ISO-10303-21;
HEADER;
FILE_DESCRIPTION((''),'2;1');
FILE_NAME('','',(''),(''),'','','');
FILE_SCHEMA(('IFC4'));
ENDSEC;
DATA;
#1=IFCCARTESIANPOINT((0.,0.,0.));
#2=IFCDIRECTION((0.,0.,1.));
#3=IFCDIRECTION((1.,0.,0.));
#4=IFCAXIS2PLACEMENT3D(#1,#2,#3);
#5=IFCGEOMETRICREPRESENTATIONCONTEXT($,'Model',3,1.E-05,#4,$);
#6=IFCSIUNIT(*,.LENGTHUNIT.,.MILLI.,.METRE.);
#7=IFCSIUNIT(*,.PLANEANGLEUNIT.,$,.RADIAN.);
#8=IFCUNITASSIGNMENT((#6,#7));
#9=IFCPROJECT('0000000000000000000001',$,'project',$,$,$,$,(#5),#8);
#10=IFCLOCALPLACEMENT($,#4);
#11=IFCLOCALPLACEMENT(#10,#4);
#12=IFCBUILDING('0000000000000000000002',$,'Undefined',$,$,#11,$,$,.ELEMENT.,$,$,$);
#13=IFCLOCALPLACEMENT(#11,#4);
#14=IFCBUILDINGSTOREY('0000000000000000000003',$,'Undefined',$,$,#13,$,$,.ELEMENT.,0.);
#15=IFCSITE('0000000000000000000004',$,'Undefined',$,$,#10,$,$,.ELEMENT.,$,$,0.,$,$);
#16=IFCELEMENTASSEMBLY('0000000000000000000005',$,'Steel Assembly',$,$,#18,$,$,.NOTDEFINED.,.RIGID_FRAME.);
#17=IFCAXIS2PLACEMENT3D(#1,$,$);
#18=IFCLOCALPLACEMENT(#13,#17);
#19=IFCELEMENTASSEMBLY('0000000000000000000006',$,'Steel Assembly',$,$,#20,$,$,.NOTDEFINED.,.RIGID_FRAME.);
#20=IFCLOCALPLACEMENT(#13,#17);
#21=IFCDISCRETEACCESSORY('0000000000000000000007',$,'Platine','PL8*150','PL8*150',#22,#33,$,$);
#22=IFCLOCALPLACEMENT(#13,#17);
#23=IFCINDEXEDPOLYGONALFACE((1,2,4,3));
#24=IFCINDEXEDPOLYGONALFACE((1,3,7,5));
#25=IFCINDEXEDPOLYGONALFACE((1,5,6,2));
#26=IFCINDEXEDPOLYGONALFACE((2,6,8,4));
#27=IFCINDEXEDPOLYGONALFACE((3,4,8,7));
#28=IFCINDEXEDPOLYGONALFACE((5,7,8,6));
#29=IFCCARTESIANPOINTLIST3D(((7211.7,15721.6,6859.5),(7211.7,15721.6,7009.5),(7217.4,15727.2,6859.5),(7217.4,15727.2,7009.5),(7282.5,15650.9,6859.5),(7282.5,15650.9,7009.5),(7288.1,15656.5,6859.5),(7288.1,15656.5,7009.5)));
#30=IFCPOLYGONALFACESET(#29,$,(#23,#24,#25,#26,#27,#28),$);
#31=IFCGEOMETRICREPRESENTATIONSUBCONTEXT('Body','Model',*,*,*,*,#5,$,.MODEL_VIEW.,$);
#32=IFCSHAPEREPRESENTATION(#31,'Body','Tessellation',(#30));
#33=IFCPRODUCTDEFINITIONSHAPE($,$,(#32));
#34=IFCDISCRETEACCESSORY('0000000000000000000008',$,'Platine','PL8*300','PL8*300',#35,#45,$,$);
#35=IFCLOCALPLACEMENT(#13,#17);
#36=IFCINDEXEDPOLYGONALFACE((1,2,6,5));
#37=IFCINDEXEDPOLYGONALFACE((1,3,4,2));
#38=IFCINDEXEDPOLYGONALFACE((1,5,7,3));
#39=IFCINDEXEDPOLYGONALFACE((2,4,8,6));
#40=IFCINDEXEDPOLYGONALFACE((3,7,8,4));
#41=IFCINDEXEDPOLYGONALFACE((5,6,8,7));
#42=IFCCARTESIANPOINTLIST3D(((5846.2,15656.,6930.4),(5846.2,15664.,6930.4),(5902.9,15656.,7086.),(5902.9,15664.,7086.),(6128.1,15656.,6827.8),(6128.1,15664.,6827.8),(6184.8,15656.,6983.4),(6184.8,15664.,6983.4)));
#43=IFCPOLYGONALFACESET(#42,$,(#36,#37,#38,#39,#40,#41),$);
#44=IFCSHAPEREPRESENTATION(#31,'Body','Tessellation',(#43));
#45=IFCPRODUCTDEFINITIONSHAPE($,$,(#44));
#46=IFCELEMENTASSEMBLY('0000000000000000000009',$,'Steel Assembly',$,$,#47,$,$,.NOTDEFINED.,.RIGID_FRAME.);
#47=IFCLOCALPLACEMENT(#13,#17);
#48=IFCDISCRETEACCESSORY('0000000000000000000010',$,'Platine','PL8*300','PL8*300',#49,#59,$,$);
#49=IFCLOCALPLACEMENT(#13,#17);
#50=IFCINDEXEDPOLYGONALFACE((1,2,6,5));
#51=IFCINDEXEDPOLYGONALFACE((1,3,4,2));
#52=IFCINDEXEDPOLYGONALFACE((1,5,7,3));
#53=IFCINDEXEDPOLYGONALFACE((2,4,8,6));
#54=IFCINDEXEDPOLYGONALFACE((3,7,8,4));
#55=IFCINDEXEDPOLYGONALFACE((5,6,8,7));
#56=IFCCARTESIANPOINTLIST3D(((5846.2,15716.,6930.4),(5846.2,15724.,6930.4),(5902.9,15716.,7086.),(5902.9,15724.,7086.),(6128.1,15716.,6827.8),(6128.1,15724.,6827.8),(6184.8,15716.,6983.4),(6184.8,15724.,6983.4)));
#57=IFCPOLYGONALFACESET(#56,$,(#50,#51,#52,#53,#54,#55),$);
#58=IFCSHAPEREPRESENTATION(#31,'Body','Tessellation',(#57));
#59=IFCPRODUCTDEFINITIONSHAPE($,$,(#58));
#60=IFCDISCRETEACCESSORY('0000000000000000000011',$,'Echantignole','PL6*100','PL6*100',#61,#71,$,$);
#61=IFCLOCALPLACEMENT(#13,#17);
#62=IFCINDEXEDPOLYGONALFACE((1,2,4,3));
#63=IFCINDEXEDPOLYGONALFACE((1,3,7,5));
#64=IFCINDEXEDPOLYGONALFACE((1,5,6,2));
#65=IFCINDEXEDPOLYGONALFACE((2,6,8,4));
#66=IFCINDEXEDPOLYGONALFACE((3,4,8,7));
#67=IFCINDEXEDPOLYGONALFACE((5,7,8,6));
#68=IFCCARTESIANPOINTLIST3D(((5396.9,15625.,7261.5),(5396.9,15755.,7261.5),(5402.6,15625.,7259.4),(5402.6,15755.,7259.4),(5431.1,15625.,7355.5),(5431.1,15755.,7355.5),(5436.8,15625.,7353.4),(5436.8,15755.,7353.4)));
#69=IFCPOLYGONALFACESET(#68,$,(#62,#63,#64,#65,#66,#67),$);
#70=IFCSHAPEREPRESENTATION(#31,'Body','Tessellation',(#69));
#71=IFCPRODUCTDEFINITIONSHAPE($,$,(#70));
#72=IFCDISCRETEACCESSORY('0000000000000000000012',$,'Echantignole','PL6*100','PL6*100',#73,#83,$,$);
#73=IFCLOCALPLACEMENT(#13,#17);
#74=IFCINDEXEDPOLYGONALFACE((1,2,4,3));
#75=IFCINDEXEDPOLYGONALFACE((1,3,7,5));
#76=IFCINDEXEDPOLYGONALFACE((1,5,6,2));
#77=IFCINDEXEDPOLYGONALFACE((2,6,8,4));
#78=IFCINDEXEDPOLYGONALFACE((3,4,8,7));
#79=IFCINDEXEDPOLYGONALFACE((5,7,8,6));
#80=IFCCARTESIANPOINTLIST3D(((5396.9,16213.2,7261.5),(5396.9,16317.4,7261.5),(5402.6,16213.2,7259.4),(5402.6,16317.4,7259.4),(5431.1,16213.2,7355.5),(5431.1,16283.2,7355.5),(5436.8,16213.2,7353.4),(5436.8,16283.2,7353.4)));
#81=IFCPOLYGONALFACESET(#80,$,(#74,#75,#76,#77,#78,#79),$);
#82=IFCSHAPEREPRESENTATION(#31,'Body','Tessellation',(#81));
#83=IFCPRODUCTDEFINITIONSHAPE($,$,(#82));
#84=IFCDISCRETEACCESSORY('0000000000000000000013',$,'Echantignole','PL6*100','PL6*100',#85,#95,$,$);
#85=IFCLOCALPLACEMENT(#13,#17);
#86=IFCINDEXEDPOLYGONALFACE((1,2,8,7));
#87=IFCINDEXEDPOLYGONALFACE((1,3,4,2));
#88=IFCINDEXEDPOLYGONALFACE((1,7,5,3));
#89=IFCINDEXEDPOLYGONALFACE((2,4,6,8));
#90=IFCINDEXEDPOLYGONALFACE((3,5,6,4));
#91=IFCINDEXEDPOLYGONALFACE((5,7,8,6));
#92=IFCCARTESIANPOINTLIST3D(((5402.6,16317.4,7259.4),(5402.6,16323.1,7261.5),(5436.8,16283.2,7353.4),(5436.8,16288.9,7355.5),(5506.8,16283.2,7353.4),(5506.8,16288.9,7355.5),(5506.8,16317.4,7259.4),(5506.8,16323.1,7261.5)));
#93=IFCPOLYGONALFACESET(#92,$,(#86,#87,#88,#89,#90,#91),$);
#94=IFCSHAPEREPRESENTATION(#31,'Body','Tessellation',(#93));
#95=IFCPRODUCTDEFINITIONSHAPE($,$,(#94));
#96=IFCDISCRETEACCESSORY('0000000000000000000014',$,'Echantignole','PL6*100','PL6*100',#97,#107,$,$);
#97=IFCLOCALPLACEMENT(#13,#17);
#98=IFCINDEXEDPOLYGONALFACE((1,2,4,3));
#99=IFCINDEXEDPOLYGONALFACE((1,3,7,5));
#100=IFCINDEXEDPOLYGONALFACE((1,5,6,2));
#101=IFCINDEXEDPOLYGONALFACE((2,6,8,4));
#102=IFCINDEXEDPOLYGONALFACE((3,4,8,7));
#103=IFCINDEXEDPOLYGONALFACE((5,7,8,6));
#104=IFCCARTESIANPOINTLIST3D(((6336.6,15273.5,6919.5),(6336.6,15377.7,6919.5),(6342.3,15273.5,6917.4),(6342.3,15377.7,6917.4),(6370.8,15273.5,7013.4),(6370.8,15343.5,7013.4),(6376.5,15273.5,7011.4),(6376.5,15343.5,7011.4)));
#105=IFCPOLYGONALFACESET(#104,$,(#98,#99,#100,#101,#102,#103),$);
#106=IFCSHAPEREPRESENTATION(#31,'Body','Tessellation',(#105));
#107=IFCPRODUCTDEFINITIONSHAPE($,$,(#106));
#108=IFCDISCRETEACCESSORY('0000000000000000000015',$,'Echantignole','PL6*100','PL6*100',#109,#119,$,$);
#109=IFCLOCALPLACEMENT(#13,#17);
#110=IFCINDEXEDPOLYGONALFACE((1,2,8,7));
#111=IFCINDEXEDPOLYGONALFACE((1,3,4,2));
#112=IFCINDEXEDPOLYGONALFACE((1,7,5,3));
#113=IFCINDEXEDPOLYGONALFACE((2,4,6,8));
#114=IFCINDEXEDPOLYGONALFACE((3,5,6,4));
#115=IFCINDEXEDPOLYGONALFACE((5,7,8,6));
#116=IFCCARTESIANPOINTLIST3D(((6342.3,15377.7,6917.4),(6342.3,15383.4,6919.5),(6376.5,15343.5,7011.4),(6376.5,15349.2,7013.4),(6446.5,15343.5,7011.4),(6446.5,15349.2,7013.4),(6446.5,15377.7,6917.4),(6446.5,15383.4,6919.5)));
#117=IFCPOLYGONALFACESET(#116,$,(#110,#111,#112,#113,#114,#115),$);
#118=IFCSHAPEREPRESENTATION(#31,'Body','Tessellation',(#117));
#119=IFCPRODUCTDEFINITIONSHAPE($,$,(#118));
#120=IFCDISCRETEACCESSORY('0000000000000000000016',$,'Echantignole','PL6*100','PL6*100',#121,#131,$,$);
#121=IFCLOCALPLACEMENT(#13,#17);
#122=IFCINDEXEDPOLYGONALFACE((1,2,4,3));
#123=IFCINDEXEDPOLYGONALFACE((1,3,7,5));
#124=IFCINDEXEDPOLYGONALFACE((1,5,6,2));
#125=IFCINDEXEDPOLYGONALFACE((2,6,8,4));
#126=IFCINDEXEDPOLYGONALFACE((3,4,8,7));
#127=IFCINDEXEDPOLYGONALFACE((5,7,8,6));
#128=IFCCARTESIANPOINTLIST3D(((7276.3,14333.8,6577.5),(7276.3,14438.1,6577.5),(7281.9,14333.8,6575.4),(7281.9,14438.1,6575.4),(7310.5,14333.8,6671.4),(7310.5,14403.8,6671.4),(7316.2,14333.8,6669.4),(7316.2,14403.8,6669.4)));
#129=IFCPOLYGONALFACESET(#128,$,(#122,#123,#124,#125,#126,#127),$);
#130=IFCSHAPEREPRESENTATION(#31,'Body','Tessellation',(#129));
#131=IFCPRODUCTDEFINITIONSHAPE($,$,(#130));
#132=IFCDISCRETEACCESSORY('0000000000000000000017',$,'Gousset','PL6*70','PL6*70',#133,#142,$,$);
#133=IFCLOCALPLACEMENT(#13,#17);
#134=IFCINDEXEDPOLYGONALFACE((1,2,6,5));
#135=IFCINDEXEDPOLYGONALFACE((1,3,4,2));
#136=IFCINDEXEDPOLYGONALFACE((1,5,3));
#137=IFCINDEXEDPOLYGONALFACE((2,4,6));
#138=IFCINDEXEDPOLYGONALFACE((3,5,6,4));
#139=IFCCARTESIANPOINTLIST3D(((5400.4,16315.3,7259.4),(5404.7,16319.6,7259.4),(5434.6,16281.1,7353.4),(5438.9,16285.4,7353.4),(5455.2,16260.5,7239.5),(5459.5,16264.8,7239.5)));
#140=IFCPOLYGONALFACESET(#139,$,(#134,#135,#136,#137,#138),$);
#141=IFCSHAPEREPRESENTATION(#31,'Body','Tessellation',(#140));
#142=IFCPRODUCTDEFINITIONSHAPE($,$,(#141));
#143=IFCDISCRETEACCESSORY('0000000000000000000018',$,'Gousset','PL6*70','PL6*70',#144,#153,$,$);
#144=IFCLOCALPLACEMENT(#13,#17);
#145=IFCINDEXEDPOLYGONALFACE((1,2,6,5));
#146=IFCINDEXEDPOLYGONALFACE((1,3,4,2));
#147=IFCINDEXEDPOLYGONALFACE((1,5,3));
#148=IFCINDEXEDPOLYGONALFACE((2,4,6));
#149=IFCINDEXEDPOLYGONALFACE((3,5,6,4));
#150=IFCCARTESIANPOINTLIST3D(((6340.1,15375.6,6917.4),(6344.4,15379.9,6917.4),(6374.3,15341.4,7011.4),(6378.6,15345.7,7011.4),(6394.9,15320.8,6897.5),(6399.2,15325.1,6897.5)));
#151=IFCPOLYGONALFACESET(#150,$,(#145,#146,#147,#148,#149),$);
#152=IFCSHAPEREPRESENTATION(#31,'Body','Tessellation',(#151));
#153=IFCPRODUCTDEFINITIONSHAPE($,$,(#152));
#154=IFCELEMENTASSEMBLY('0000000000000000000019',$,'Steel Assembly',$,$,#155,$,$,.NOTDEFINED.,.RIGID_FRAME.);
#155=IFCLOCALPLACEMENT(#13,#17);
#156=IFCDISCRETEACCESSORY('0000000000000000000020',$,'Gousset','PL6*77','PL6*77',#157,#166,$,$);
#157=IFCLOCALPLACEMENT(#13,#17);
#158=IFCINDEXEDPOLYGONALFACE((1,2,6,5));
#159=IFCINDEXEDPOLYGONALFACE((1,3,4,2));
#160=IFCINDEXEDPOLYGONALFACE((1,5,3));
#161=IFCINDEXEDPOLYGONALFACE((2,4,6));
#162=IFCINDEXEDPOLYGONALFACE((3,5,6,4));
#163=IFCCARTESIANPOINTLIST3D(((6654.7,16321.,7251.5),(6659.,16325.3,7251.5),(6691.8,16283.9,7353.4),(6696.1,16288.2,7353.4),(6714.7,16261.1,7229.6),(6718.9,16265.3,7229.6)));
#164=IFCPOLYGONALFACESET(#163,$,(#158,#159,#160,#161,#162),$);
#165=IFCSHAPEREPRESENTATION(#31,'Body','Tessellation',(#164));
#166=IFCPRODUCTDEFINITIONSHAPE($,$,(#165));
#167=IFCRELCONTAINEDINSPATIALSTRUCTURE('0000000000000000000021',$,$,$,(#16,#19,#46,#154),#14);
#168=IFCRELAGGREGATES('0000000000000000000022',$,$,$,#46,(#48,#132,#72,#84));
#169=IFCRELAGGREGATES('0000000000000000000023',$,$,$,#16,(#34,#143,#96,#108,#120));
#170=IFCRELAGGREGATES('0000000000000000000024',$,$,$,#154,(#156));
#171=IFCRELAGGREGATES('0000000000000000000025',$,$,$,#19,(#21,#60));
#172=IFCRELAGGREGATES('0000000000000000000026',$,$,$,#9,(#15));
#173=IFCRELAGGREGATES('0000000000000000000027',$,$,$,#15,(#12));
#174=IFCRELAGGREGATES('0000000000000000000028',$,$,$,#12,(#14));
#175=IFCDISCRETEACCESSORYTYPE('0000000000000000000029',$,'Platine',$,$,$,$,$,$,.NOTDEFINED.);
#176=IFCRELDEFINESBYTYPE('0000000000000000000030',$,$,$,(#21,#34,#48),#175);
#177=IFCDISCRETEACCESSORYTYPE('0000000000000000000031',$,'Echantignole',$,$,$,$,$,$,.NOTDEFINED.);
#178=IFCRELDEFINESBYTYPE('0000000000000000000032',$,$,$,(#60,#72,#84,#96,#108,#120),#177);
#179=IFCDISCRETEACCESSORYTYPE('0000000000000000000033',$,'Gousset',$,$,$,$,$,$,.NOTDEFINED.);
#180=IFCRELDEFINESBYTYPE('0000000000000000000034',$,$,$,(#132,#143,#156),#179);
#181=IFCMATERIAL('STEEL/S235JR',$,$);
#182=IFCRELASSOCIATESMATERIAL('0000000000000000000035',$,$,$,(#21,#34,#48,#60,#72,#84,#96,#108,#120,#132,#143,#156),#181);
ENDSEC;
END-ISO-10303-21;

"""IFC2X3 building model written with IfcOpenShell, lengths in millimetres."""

from ifc_helpers import new_model, si_unit, frame, origin_with_axes, origin_2d_with_axis, place, context, subcontext, project, spatial, polyline, rectangle, outline, extrude, material, type_object, element, aggregate, save


model = new_model("IFC2X3")

# Units and contexts
model_context = context("Model", 3, precision=1e-05, world=origin_with_axes())
body_context = subcontext(model_context, "Body", "Model", "MODEL_VIEW")
ifc_project = project(units=[si_unit("LENGTHUNIT", "METRE", prefix="MILLI"), si_unit("PLANEANGLEUNIT", "RADIAN")], contexts=[model_context])

# Site, building, storey
site_placement = place(None, origin_with_axes())
site = spatial("IfcSite", under=ifc_project, at=site_placement, Name="Undefined", CompositionType="ELEMENT", RefElevation=0.0)
building_placement = place(site_placement, origin_with_axes())
building = spatial("IfcBuilding", under=site, at=building_placement, Name="Undefined", CompositionType="ELEMENT")
storey_placement = place(building_placement, origin_with_axes())
storey = spatial("IfcBuildingStorey", under=building, at=storey_placement, Name="Undefined", CompositionType="ELEMENT", Elevation=0.0)

# Element assembly
assembly_1_placement = place(storey_placement, origin_with_axes())
assembly_1 = element("IfcElementAssembly", 1, at=assembly_1_placement, inside=storey, Name="Steel Assembly", AssemblyPlace="NOTDEFINED", PredefinedType="RIGID_FRAME")
ifc_material_1 = material(Name="STEEL/S235JR")

# Element assembly, discrete accessory
assembly_2_placement = place(storey_placement, origin_with_axes())
assembly_2 = element("IfcElementAssembly", 2, at=assembly_2_placement, inside=storey, Name="Steel Assembly", AssemblyPlace="NOTDEFINED", PredefinedType="RIGID_FRAME")
discrete_accessory_type_1 = type_object("IfcDiscreteAccessoryType", Name="Platine")
discrete_accessory_1_placement = place(assembly_2_placement, frame((7214.6, 15724.4, 6934.5), z_axis=(0.707107, 0.707107, 0.0), x_axis=(0.707107, -0.707107, 0.0)))
discrete_accessory_1 = element("IfcDiscreteAccessory", 3, at=discrete_accessory_1_placement, type_object=discrete_accessory_type_1, material=ifc_material_1, Name="Platine", Description="PL8*150", ObjectType="PL8*150", context=body_context, shape_type="SweptSolid", body=[
    extrude(outline(polyline([(100.0, 75.0), (100.0, -75.0), (0.0, -75.0), (0.0, 75.0), (100.0, 75.0)])), frame((0.0, 0.0, -4.0), z_axis=(0.0, 0.0, 1.0), x_axis=(1.0, 0.0, 0.0)), (0.0, 0.0, 1.0), 8.0),
])

# Discrete accessory
discrete_accessory_2_placement = place(assembly_1_placement, frame((6043.8, 15660.0, 7034.8), z_axis=(0.939693, 0.0, -0.34202), x_axis=(-0.34202, 0.0, -0.939693)))
discrete_accessory_2 = element("IfcDiscreteAccessory", 4, at=discrete_accessory_2_placement, type_object=discrete_accessory_type_1, material=ifc_material_1, Name="Platine", Description="PL8*300", ObjectType="PL8*300", context=body_context, shape_type="SweptSolid", body=[
    extrude(rectangle(XDim=8.0, YDim=300.0, at=origin_2d_with_axis()), frame((165.6, 0.0, 0.0), z_axis=(-1.0, 0.0, 0.0), x_axis=(0.0, -1.0, 0.0)), (0.0, 0.0, 1.0), 165.6),
])

# Element assembly, discrete accessory
assembly_3_placement = place(storey_placement, origin_with_axes())
assembly_3 = element("IfcElementAssembly", 5, at=assembly_3_placement, inside=storey, Name="Steel Assembly", AssemblyPlace="NOTDEFINED", PredefinedType="RIGID_FRAME")
discrete_accessory_3_placement = place(assembly_3_placement, frame((6043.8, 15720.0, 7034.8), z_axis=(-0.939693, 0.0, 0.34202), x_axis=(-0.34202, 0.0, -0.939693)))
discrete_accessory_3 = element("IfcDiscreteAccessory", 6, at=discrete_accessory_3_placement, type_object=discrete_accessory_type_1, material=ifc_material_1, Name="Platine", Description="PL8*300", ObjectType="PL8*300", context=body_context, shape_type="SweptSolid", body=[
    extrude(rectangle(XDim=8.0, YDim=300.0, at=origin_2d_with_axis()), frame((165.6, 0.0, 0.0), z_axis=(-1.0, 0.0, 0.0), x_axis=(0.0, -1.0, 0.0)), (0.0, 0.0, 1.0), 165.6),
])

# Discrete accessories
discrete_accessory_type_2 = type_object("IfcDiscreteAccessoryType", Name="Echantignole")
discrete_accessory_4_placement = place(assembly_2_placement, frame((5416.8, 15625.0, 7307.5), z_axis=(0.939693, 0.0, -0.34202), x_axis=(0.0, 1.0, 0.0)))
discrete_accessory_4 = element("IfcDiscreteAccessory", 7, at=discrete_accessory_4_placement, type_object=discrete_accessory_type_2, material=ifc_material_1, Name="Echantignole", Description="PL6*100", ObjectType="PL6*100", context=body_context, shape_type="SweptSolid", body=[
    extrude(outline(polyline([(0.0, 50.0), (130.0, 50.0), (130.0, -50.0), (0.0, -50.0), (0.0, 50.0)])), frame((0.0, 0.0, -3.0), z_axis=(0.0, 0.0, 1.0), x_axis=(1.0, 0.0, 0.0)), (0.0, 0.0, 1.0), 6.0),
])
discrete_accessory_5_placement = place(assembly_3_placement, frame((5433.9, 16283.2, 7354.4), z_axis=(0.939693, 0.0, -0.34202), x_axis=(0.0, -1.0, 0.0)))
discrete_accessory_5 = element("IfcDiscreteAccessory", 8, at=discrete_accessory_5_placement, type_object=discrete_accessory_type_2, material=ifc_material_1, Name="Echantignole", Description="PL6*100", ObjectType="PL6*100", context=body_context, shape_type="SweptSolid", body=[
    extrude(outline(polyline([(0.0, 0.0), (70.0, 0.0), (70.0, 100.0), (-34.2, 100.0), (0.0, 0.0)])), frame((0.0, 0.0, -3.0), z_axis=(0.0, 0.0, 1.0), x_axis=(1.0, 0.0, 0.0)), (0.0, 0.0, 1.0), 6.0),
])
discrete_accessory_6_placement = place(assembly_3_placement, frame((5436.8, 16286.1, 7354.4), z_axis=(0.0, 0.939693, 0.34202), x_axis=(1.0, 0.0, 0.0)))
discrete_accessory_6 = element("IfcDiscreteAccessory", 9, at=discrete_accessory_6_placement, type_object=discrete_accessory_type_2, material=ifc_material_1, Name="Echantignole", Description="PL6*100", ObjectType="PL6*100", context=body_context, shape_type="SweptSolid", body=[
    extrude(outline(polyline([(0.0, 0.0), (70.0, 0.0), (70.0, 100.0), (-34.2, 100.0), (0.0, 0.0)])), frame((0.0, 0.0, -3.0), z_axis=(0.0, 0.0, 1.0), x_axis=(1.0, 0.0, 0.0)), (0.0, 0.0, 1.0), 6.0),
])
discrete_accessory_7_placement = place(assembly_1_placement, frame((6373.6, 15343.5, 7012.4), z_axis=(0.939693, 0.0, -0.34202), x_axis=(0.0, -1.0, 0.0)))
discrete_accessory_7 = element("IfcDiscreteAccessory", 10, at=discrete_accessory_7_placement, type_object=discrete_accessory_type_2, material=ifc_material_1, Name="Echantignole", Description="PL6*100", ObjectType="PL6*100", context=body_context, shape_type="SweptSolid", body=[
    extrude(outline(polyline([(0.0, 0.0), (70.0, 0.0), (70.0, 100.0), (-34.2, 100.0), (0.0, 0.0)])), frame((0.0, 0.0, -3.0), z_axis=(0.0, 0.0, 1.0), x_axis=(1.0, 0.0, 0.0)), (0.0, 0.0, 1.0), 6.0),
])
discrete_accessory_8_placement = place(assembly_1_placement, frame((6376.5, 15346.4, 7012.4), z_axis=(0.0, 0.939693, 0.34202), x_axis=(1.0, 0.0, 0.0)))
discrete_accessory_8 = element("IfcDiscreteAccessory", 11, at=discrete_accessory_8_placement, type_object=discrete_accessory_type_2, material=ifc_material_1, Name="Echantignole", Description="PL6*100", ObjectType="PL6*100", context=body_context, shape_type="SweptSolid", body=[
    extrude(outline(polyline([(0.0, 0.0), (70.0, 0.0), (70.0, 100.0), (-34.2, 100.0), (0.0, 0.0)])), frame((0.0, 0.0, -3.0), z_axis=(0.0, 0.0, 1.0), x_axis=(1.0, 0.0, 0.0)), (0.0, 0.0, 1.0), 6.0),
])
discrete_accessory_9_placement = place(assembly_1_placement, frame((7313.3, 14403.8, 6670.4), z_axis=(0.939693, 0.0, -0.34202), x_axis=(0.0, -1.0, 0.0)))
discrete_accessory_9 = element("IfcDiscreteAccessory", 12, at=discrete_accessory_9_placement, type_object=discrete_accessory_type_2, material=ifc_material_1, Name="Echantignole", Description="PL6*100", ObjectType="PL6*100", context=body_context, shape_type="SweptSolid", body=[
    extrude(outline(polyline([(0.0, 0.0), (70.0, 0.0), (70.0, 100.0), (-34.2, 100.0), (0.0, 0.0)])), frame((0.0, 0.0, -3.0), z_axis=(0.0, 0.0, 1.0), x_axis=(1.0, 0.0, 0.0)), (0.0, 0.0, 1.0), 6.0),
])
discrete_accessory_type_3 = type_object("IfcDiscreteAccessoryType", Name="Gousset")
discrete_accessory_10_placement = place(assembly_3_placement, frame((5436.8, 16283.2, 7353.4), z_axis=(-0.707107, -0.707107, 0.0), x_axis=(-0.323616, 0.323616, -0.889126)))
discrete_accessory_10 = element("IfcDiscreteAccessory", 13, at=discrete_accessory_10_placement, type_object=discrete_accessory_type_3, material=ifc_material_1, Name="Gousset", Description="PL6*70", ObjectType="PL6*70", context=body_context, shape_type="SweptSolid", body=[
    extrude(outline(polyline([(0.0, 0.0), (105.7, 0.0), (88.0, 78.0), (0.0, 0.0)])), frame((0.0, 0.0, -3.0), z_axis=(0.0, 0.0, 1.0), x_axis=(1.0, 0.0, 0.0)), (0.0, 0.0, 1.0), 6.0),
])
aggregate(assembly_3, [discrete_accessory_3, discrete_accessory_10, discrete_accessory_5, discrete_accessory_6])
discrete_accessory_11_placement = place(assembly_1_placement, frame((6376.5, 15343.5, 7011.4), z_axis=(-0.707107, -0.707107, 0.0), x_axis=(-0.323616, 0.323616, -0.889126)))
discrete_accessory_11 = element("IfcDiscreteAccessory", 14, at=discrete_accessory_11_placement, type_object=discrete_accessory_type_3, material=ifc_material_1, Name="Gousset", Description="PL6*70", ObjectType="PL6*70", context=body_context, shape_type="SweptSolid", body=[
    extrude(outline(polyline([(0.0, 0.0), (105.7, 0.0), (88.0, 78.0), (0.0, 0.0)])), frame((0.0, 0.0, -3.0), z_axis=(0.0, 0.0, 1.0), x_axis=(1.0, 0.0, 0.0)), (0.0, 0.0, 1.0), 6.0),
])
aggregate(assembly_1, [discrete_accessory_2, discrete_accessory_11, discrete_accessory_7, discrete_accessory_8, discrete_accessory_9])

# Element assembly, discrete accessory
assembly_4_placement = place(storey_placement, origin_with_axes())
assembly_4 = element("IfcElementAssembly", 15, at=assembly_4_placement, inside=storey, Name="Steel Assembly", AssemblyPlace="NOTDEFINED", PredefinedType="RIGID_FRAME")
discrete_accessory_12_placement = place(assembly_4_placement, frame((6693.9, 16286.1, 7353.4), z_axis=(-0.707107, -0.707107, 0.0), x_axis=(-0.323616, 0.323616, -0.889126)))
discrete_accessory_12 = element("IfcDiscreteAccessory", 16, at=discrete_accessory_12_placement, type_object=discrete_accessory_type_3, material=ifc_material_1, Name="Gousset", Description="PL6*77", ObjectType="PL6*77", context=body_context, shape_type="SweptSolid", body=[
    extrude(outline(polyline([(0.0, 0.0), (114.7, 0.0), (95.3, 85.4), (0.0, 0.0)])), frame((0.0, 0.0, -3.0), z_axis=(0.0, 0.0, 1.0), x_axis=(1.0, 0.0, 0.0)), (0.0, 0.0, 1.0), 6.0),
])

aggregate(assembly_4, [discrete_accessory_12])

aggregate(assembly_2, [discrete_accessory_1, discrete_accessory_4])

save(model, "model.ifc")
